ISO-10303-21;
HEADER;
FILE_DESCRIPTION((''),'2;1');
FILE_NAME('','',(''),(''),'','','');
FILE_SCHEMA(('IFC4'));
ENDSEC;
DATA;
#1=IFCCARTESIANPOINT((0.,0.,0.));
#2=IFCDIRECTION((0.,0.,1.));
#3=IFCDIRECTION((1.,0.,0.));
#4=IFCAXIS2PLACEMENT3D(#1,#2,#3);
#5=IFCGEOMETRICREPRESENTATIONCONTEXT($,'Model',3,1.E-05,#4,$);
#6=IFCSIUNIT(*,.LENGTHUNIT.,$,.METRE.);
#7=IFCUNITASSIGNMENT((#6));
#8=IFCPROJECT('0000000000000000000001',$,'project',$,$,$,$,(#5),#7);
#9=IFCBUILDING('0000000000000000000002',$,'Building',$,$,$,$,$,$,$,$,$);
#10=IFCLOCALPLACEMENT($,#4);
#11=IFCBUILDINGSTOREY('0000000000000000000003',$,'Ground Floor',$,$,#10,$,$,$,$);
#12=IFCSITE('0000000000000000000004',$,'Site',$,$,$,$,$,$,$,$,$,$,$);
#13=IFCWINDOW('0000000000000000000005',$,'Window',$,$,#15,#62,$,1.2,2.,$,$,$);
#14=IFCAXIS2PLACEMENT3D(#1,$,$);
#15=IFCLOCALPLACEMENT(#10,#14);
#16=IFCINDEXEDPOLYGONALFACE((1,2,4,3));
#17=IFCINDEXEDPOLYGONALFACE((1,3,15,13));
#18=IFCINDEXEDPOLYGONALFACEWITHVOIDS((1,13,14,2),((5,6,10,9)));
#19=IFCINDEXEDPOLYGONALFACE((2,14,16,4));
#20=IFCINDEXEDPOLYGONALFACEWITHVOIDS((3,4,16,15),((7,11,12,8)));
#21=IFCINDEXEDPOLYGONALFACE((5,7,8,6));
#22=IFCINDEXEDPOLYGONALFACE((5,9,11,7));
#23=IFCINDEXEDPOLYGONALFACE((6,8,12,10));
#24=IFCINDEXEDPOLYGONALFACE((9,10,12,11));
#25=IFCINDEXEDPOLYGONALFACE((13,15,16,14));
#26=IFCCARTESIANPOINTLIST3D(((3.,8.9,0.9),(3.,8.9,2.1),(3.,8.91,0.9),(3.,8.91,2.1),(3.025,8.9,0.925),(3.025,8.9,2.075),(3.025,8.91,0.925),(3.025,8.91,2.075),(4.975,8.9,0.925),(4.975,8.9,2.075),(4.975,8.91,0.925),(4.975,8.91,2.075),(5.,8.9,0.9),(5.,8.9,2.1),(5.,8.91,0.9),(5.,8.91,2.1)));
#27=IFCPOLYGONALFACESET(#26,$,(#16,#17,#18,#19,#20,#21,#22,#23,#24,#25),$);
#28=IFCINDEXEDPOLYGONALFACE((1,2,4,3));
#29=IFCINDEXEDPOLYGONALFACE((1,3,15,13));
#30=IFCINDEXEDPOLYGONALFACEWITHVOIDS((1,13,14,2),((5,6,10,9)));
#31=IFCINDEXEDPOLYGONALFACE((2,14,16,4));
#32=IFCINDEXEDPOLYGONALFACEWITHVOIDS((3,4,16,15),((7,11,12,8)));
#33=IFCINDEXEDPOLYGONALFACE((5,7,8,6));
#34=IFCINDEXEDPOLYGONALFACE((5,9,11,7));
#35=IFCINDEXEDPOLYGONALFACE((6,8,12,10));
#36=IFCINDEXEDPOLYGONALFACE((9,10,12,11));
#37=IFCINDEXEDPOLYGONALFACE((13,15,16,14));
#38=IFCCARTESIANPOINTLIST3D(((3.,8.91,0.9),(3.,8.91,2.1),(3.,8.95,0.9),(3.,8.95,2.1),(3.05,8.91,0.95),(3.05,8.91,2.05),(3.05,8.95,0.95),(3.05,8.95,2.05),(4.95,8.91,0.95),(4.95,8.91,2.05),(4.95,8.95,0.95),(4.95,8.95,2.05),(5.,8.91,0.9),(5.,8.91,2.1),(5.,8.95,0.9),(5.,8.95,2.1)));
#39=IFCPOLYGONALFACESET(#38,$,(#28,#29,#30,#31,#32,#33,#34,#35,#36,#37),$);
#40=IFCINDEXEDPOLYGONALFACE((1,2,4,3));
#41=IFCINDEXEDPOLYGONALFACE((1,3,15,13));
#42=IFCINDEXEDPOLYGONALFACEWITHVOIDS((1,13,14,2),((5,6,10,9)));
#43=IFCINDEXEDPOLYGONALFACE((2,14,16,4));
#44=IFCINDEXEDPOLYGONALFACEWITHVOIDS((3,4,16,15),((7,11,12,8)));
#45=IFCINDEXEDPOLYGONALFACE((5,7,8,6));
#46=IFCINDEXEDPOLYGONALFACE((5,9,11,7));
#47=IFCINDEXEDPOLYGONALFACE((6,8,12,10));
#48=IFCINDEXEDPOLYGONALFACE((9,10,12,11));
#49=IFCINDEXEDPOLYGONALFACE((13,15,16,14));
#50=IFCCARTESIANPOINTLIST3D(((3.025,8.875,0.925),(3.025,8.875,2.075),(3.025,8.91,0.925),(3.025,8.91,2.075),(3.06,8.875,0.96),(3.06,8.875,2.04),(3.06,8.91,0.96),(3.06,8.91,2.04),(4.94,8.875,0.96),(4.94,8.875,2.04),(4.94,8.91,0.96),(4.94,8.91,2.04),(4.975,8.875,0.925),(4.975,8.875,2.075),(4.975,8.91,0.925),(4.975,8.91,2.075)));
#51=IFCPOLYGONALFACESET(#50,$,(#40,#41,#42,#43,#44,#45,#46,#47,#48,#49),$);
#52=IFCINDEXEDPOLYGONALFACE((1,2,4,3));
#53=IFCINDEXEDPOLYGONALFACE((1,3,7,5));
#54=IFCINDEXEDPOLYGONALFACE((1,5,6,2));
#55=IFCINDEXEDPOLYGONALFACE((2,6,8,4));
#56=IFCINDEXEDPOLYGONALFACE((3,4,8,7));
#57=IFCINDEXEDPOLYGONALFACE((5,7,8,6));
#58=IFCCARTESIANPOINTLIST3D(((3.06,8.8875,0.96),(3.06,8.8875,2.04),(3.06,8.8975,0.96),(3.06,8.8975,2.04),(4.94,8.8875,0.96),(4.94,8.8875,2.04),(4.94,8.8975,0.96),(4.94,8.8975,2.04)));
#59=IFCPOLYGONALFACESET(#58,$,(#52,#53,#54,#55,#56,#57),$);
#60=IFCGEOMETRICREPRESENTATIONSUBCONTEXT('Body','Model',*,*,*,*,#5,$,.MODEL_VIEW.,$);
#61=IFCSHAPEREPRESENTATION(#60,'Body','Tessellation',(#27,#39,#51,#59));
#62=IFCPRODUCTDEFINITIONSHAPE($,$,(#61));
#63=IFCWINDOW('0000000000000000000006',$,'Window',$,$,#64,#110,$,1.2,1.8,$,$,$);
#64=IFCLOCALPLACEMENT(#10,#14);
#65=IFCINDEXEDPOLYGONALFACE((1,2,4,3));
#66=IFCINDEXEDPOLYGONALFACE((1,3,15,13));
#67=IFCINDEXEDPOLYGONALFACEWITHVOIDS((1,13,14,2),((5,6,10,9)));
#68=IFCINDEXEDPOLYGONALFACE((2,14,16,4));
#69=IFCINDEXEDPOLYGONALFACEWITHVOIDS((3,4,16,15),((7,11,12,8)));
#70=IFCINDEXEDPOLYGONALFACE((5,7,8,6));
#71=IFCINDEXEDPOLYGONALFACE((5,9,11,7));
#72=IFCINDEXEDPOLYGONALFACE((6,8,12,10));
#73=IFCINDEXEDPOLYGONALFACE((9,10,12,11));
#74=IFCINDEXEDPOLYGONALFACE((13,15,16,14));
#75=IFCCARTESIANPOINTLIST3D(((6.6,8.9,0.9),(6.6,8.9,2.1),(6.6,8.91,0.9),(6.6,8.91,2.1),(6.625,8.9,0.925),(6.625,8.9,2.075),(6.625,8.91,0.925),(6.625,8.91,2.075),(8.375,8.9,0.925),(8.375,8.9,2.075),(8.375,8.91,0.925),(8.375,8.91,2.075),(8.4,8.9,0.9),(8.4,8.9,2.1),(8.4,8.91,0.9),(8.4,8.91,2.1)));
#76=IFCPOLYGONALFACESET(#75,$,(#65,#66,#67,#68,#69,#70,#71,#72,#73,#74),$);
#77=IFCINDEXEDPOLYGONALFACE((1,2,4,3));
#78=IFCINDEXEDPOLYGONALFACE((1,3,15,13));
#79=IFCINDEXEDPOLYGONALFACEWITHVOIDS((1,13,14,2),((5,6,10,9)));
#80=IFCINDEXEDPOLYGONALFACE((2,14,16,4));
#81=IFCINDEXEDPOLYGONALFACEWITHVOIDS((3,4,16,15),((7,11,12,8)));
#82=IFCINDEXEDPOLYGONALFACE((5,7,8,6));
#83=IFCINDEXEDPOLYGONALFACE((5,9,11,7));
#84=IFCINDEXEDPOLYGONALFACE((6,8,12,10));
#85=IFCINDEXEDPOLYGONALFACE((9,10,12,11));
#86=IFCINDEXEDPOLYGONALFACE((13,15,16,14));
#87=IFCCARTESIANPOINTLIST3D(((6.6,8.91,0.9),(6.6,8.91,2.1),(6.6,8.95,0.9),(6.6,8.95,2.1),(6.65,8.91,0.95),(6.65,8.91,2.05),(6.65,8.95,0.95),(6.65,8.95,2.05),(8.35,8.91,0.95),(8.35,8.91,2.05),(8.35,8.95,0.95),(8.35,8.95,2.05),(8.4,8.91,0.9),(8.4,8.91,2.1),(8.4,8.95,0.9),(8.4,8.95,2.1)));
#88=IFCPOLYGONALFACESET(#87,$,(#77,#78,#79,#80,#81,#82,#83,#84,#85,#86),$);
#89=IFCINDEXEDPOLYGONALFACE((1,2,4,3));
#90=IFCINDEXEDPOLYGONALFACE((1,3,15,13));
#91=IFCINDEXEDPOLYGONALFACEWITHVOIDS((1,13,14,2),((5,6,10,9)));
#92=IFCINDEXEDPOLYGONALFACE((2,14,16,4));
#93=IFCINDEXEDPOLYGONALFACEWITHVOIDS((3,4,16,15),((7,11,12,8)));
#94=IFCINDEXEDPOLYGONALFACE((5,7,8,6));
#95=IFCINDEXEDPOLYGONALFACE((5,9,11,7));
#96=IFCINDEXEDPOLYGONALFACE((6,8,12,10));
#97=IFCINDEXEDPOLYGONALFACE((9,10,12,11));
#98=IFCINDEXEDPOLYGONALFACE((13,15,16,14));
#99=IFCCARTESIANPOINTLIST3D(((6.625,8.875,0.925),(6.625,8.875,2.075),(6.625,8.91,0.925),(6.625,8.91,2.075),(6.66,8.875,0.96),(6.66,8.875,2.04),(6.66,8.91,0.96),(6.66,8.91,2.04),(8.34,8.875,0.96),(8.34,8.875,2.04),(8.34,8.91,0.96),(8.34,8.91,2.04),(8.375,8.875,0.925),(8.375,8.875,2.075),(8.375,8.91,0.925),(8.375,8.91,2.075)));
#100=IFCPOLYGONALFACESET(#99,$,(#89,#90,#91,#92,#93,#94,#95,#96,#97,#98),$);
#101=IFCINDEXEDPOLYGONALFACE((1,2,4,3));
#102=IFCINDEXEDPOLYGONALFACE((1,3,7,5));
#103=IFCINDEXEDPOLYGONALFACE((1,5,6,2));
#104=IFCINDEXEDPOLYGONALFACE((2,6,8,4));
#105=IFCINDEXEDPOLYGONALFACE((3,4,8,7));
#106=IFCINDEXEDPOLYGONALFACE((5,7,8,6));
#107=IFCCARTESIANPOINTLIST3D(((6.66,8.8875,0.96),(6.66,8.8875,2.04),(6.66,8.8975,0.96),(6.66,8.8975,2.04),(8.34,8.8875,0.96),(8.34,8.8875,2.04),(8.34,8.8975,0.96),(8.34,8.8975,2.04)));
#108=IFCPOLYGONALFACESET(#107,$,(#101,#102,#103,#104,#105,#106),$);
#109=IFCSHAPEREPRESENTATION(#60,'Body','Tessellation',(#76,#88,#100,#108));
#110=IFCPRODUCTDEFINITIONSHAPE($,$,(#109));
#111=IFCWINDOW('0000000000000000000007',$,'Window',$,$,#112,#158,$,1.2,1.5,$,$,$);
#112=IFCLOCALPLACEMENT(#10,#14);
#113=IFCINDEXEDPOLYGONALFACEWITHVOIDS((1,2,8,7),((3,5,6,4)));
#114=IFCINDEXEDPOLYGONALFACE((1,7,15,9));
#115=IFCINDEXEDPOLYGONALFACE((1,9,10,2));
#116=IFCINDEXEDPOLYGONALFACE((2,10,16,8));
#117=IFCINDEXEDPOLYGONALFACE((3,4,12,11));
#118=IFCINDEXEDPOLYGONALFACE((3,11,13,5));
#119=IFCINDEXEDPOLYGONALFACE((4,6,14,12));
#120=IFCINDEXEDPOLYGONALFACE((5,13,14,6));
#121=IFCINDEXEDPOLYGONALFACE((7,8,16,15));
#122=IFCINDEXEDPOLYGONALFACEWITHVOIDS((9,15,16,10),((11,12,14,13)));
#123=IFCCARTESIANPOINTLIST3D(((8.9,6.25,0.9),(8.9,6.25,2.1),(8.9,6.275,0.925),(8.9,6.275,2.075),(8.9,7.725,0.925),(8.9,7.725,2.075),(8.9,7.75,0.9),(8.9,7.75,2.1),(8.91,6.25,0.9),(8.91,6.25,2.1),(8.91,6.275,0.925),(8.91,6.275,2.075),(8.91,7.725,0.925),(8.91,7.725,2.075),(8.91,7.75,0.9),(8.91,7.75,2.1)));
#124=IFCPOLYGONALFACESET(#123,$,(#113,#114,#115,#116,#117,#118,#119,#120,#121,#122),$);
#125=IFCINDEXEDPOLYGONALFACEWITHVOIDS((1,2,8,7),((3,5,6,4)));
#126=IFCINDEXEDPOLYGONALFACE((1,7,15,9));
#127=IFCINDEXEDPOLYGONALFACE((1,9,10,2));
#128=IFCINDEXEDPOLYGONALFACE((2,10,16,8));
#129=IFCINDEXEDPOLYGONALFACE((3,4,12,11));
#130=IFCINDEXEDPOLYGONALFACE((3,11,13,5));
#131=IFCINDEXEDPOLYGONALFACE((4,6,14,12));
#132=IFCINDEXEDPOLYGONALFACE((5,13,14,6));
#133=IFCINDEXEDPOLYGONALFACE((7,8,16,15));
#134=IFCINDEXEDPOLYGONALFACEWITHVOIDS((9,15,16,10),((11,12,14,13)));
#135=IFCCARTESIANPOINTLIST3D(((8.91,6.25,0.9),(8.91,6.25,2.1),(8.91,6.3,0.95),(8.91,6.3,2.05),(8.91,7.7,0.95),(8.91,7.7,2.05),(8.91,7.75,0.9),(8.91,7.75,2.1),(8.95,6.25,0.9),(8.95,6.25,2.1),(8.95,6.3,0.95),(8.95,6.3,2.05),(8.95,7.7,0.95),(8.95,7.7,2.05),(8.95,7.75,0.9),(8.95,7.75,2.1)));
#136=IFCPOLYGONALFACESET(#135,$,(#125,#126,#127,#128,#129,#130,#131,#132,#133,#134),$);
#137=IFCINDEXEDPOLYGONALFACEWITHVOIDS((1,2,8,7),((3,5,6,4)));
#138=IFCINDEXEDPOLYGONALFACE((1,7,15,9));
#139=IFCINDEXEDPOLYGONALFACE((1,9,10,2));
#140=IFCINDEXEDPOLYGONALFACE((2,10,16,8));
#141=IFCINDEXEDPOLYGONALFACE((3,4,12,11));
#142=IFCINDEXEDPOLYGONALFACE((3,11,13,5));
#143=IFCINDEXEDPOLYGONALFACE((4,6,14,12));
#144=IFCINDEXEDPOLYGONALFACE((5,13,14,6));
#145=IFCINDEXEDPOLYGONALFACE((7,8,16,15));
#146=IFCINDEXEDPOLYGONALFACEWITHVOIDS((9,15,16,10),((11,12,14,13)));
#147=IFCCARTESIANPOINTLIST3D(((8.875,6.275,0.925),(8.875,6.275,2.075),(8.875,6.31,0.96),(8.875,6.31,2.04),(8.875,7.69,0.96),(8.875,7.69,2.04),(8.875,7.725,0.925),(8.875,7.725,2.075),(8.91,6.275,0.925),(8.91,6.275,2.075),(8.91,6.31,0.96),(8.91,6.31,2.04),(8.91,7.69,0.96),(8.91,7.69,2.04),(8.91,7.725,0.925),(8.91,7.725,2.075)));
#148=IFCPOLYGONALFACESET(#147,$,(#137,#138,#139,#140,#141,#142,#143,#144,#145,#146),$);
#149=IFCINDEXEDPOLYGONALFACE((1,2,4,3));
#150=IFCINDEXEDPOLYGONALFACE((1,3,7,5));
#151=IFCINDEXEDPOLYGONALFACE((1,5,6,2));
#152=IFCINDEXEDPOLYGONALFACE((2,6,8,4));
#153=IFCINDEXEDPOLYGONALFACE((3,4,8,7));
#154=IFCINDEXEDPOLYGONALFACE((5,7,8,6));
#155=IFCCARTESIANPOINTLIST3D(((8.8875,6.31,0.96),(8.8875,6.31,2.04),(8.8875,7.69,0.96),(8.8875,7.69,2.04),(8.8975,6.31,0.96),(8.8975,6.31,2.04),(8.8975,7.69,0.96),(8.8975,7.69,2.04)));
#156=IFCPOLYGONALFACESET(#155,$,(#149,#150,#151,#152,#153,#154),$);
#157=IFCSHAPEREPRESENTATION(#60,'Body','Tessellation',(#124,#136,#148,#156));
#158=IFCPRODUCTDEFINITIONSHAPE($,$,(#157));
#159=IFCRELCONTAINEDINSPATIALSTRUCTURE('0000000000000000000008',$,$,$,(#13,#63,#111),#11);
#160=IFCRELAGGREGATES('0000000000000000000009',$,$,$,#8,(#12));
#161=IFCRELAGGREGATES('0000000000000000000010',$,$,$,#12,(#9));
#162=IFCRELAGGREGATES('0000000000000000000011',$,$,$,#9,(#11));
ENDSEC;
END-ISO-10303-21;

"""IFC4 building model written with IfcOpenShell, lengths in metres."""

from ifc_helpers import new_model, si_unit, frame, origin_with_axes, place, context, subcontext, project, spatial, line, indexed_curve, outline, extrude, element, save


model = new_model("IFC4")

# Units and contexts
model_context = context("Model", 3, precision=1e-05, world=origin_with_axes())
body_context = subcontext(model_context, "Body", "Model", "MODEL_VIEW")
ifc_project = project(units=[si_unit("LENGTHUNIT", "METRE")], contexts=[model_context])

# Site, building, storey
site = spatial("IfcSite", under=ifc_project, Name="Site")
building = spatial("IfcBuilding", under=site, Name="Building")
storey_placement = place(None, origin_with_axes())
storey = spatial("IfcBuildingStorey", under=building, at=storey_placement, Name="Ground Floor")

# Windows
window_1_placement = place(storey_placement, frame((5.0, 9.0, 0.9), z_axis=(0.0, 0.0, 1.0), x_axis=(-1.0, 0.0, 0.0)))
element("IfcWindow", 1, at=window_1_placement, inside=storey, Name="Window", OverallHeight=1.2, OverallWidth=2.0, context=body_context, shape_type="SweptSolid", body=[
    extrude(outline(indexed_curve([(0.0, 0.0), (2.0, 0.0), (2.0, 1.2), (0.0, 1.2)], segments=[line(1, 2, 3, 4, 1)]), holes=[indexed_curve([(0.025, 0.025), (1.975, 0.025), (1.975, 1.175), (0.025, 1.175)], segments=[line(1, 2, 3, 4, 1)])]), frame((0.0, 0.09, 0.0), z_axis=(0.0, -1.0, 0.0), x_axis=(1.0, 0.0, 0.0)), (0.0, 0.0, -1.0), 0.01),
    extrude(outline(indexed_curve([(0.0, 0.0), (2.0, 0.0), (2.0, 1.2), (0.0, 1.2)], segments=[line(1, 2, 3, 4, 1)]), holes=[indexed_curve([(0.05, 0.05), (1.95, 0.05), (1.95, 1.15), (0.05, 1.15)], segments=[line(1, 2, 3, 4, 1)])]), frame((0.0, 0.05, 0.0), z_axis=(0.0, -1.0, 0.0), x_axis=(1.0, 0.0, 0.0)), (0.0, 0.0, -1.0), 0.04),
    extrude(outline(indexed_curve([(0.0, 0.0), (1.95, 0.0), (1.95, 1.15), (0.0, 1.15)], segments=[line(1, 2, 3, 4, 1)]), holes=[indexed_curve([(0.035, 0.035), (1.915, 0.035), (1.915, 1.115), (0.035, 1.115)], segments=[line(1, 2, 3, 4, 1)])]), frame((0.025, 0.09, 0.025), z_axis=(0.0, -1.0, 0.0), x_axis=(1.0, 0.0, 0.0)), (0.0, 0.0, -1.0), 0.035),
    extrude(outline(indexed_curve([(0.035, 0.035), (1.915, 0.035), (1.915, 1.115), (0.035, 1.115)], segments=[line(1, 2, 3, 4, 1)])), frame((0.025, 0.1025, 0.025), z_axis=(0.0, -1.0, 0.0), x_axis=(1.0, 0.0, 0.0)), (0.0, 0.0, -1.0), 0.01),
])
window_2_placement = place(storey_placement, frame((8.4, 9.0, 0.9), z_axis=(0.0, 0.0, 1.0), x_axis=(-1.0, 0.0, 0.0)))
element("IfcWindow", 2, at=window_2_placement, inside=storey, Name="Window", OverallHeight=1.2, OverallWidth=1.8, context=body_context, shape_type="SweptSolid", body=[
    extrude(outline(indexed_curve([(0.0, 0.0), (1.8, 0.0), (1.8, 1.2), (0.0, 1.2)], segments=[line(1, 2, 3, 4, 1)]), holes=[indexed_curve([(0.025, 0.025), (1.775, 0.025), (1.775, 1.175), (0.025, 1.175)], segments=[line(1, 2, 3, 4, 1)])]), frame((0.0, 0.09, 0.0), z_axis=(0.0, -1.0, 0.0), x_axis=(1.0, 0.0, 0.0)), (0.0, 0.0, -1.0), 0.01),
    extrude(outline(indexed_curve([(0.0, 0.0), (1.8, 0.0), (1.8, 1.2), (0.0, 1.2)], segments=[line(1, 2, 3, 4, 1)]), holes=[indexed_curve([(0.05, 0.05), (1.75, 0.05), (1.75, 1.15), (0.05, 1.15)], segments=[line(1, 2, 3, 4, 1)])]), frame((0.0, 0.05, 0.0), z_axis=(0.0, -1.0, 0.0), x_axis=(1.0, 0.0, 0.0)), (0.0, 0.0, -1.0), 0.04),
    extrude(outline(indexed_curve([(0.0, 0.0), (1.75, 0.0), (1.75, 1.15), (0.0, 1.15)], segments=[line(1, 2, 3, 4, 1)]), holes=[indexed_curve([(0.035, 0.035), (1.715, 0.035), (1.715, 1.115), (0.035, 1.115)], segments=[line(1, 2, 3, 4, 1)])]), frame((0.025, 0.09, 0.025), z_axis=(0.0, -1.0, 0.0), x_axis=(1.0, 0.0, 0.0)), (0.0, 0.0, -1.0), 0.035),
    extrude(outline(indexed_curve([(0.035, 0.035), (1.715, 0.035), (1.715, 1.115), (0.035, 1.115)], segments=[line(1, 2, 3, 4, 1)])), frame((0.025, 0.1025, 0.025), z_axis=(0.0, -1.0, 0.0), x_axis=(1.0, 0.0, 0.0)), (0.0, 0.0, -1.0), 0.01),
])
window_3_placement = place(storey_placement, frame((9.0, 6.25, 0.9), z_axis=(0.0, 0.0, 1.0), x_axis=(0.0, 1.0, 0.0)))
element("IfcWindow", 3, at=window_3_placement, inside=storey, Name="Window", OverallHeight=1.2, OverallWidth=1.5, context=body_context, shape_type="SweptSolid", body=[
    extrude(outline(indexed_curve([(0.0, 0.0), (1.5, 0.0), (1.5, 1.2), (0.0, 1.2)], segments=[line(1, 2, 3, 4, 1)]), holes=[indexed_curve([(0.025, 0.025), (1.475, 0.025), (1.475, 1.175), (0.025, 1.175)], segments=[line(1, 2, 3, 4, 1)])]), frame((0.0, 0.09, 0.0), z_axis=(0.0, -1.0, 0.0), x_axis=(1.0, 0.0, 0.0)), (0.0, 0.0, -1.0), 0.01),
    extrude(outline(indexed_curve([(0.0, 0.0), (1.5, 0.0), (1.5, 1.2), (0.0, 1.2)], segments=[line(1, 2, 3, 4, 1)]), holes=[indexed_curve([(0.05, 0.05), (1.45, 0.05), (1.45, 1.15), (0.05, 1.15)], segments=[line(1, 2, 3, 4, 1)])]), frame((0.0, 0.05, 0.0), z_axis=(0.0, -1.0, 0.0), x_axis=(1.0, 0.0, 0.0)), (0.0, 0.0, -1.0), 0.04),
    extrude(outline(indexed_curve([(0.0, 0.0), (1.45, 0.0), (1.45, 1.15), (0.0, 1.15)], segments=[line(1, 2, 3, 4, 1)]), holes=[indexed_curve([(0.035, 0.035), (1.415, 0.035), (1.415, 1.115), (0.035, 1.115)], segments=[line(1, 2, 3, 4, 1)])]), frame((0.025, 0.09, 0.025), z_axis=(0.0, -1.0, 0.0), x_axis=(1.0, 0.0, 0.0)), (0.0, 0.0, -1.0), 0.035),
    extrude(outline(indexed_curve([(0.035, 0.035), (1.415, 0.035), (1.415, 1.115), (0.035, 1.115)], segments=[line(1, 2, 3, 4, 1)])), frame((0.025, 0.1025, 0.025), z_axis=(0.0, -1.0, 0.0), x_axis=(1.0, 0.0, 0.0)), (0.0, 0.0, -1.0), 0.01),
])

save(model, "model.ifc")
